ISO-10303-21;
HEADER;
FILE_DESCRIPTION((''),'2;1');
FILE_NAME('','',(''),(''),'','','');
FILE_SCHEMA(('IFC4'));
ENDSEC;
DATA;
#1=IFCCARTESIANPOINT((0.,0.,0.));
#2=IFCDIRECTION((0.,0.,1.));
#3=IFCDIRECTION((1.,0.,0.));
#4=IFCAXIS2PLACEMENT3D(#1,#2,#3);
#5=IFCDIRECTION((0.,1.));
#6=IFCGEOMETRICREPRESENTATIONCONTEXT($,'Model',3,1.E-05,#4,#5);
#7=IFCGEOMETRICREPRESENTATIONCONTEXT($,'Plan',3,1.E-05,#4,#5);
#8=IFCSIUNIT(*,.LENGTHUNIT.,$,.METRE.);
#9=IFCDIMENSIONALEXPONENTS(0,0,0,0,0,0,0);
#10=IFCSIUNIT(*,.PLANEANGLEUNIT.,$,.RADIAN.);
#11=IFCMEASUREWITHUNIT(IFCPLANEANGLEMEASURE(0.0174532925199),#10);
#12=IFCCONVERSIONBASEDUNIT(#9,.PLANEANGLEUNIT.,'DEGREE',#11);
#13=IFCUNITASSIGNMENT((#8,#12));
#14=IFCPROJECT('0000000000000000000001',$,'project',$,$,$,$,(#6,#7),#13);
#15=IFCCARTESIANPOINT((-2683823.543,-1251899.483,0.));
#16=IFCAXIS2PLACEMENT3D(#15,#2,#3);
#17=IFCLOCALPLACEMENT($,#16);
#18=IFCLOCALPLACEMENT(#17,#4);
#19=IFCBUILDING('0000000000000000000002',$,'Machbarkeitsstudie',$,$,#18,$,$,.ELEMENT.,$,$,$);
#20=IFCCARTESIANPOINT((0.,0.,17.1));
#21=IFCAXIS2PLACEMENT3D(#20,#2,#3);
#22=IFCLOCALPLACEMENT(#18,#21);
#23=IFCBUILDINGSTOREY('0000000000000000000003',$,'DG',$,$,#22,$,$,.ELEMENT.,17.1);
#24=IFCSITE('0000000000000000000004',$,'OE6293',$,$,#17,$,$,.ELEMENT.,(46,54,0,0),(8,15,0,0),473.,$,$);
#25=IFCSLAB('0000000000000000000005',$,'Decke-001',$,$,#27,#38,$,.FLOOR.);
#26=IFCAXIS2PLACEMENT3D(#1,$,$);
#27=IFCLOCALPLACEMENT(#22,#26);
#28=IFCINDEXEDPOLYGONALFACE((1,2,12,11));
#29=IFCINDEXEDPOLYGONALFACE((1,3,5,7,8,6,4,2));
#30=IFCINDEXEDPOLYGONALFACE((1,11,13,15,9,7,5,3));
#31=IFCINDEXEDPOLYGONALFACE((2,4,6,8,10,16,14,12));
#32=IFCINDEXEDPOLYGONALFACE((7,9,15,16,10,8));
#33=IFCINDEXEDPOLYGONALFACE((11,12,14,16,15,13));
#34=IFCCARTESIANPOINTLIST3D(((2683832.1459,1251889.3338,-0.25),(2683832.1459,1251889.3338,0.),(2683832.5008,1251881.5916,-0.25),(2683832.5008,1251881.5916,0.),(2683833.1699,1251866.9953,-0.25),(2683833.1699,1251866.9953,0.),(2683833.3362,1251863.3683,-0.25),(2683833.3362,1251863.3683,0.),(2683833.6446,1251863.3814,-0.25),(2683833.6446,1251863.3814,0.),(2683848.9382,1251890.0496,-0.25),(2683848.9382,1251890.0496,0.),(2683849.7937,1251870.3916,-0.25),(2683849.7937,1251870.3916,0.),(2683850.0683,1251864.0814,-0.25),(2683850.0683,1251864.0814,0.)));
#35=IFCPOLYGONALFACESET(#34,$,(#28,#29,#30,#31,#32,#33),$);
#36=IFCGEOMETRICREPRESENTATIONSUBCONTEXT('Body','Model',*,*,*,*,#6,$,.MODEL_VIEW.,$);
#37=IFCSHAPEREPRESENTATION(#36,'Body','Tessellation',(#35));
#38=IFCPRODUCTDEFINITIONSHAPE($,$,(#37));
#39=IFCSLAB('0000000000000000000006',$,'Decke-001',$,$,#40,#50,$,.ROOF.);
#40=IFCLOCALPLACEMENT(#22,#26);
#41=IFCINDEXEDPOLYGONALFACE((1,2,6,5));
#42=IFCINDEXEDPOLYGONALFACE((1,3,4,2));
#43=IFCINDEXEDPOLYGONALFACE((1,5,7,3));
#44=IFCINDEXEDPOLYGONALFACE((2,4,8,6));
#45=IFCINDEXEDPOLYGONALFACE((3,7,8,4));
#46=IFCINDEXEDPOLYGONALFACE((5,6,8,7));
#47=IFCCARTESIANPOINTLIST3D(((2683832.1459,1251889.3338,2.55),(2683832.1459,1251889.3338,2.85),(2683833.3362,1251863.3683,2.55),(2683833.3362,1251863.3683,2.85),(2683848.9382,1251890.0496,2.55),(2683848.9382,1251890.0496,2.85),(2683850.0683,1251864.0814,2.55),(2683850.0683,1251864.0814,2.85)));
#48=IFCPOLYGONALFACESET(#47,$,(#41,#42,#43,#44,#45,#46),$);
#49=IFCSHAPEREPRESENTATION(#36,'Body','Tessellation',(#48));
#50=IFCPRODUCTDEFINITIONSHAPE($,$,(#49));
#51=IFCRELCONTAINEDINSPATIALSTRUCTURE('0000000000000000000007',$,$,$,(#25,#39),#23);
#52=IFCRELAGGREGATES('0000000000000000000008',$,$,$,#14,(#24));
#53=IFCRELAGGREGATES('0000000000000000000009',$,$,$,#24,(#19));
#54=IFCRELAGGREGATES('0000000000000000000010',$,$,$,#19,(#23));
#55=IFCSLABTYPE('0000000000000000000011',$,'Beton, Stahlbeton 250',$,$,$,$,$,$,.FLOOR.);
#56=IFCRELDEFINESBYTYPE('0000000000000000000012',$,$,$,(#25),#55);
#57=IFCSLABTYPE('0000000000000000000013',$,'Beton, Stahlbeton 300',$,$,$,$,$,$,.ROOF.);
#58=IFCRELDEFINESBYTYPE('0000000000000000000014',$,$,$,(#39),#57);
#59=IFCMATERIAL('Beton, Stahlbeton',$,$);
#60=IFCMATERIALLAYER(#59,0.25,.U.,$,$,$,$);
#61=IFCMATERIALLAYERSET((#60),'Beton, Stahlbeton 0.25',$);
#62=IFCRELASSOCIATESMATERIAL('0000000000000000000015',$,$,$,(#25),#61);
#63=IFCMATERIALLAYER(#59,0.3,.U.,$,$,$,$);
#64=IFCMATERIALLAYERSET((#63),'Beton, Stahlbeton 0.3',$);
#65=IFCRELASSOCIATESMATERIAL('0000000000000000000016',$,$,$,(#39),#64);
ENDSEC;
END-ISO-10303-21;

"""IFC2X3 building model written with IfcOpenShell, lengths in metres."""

from ifc_helpers import new_model, entity, si_unit, converted_unit, direction, frame, origin_with_axes, place, context, subcontext, project, spatial, polyline, outline, extrude, material, layer, layer_set, layer_usage, type_object, element, save


model = new_model("IFC2X3")

# Units and contexts
model_context = context("Model", 3, precision=1e-05, world=origin_with_axes(), true_north=direction((0.0, 1.0)))
plan_context = context("Plan", 3, precision=1e-05, world=origin_with_axes(), true_north=direction((0.0, 1.0)))
body_context = subcontext(model_context, "Body", "Model", "MODEL_VIEW")
ifc_project = project(units=[si_unit("LENGTHUNIT", "METRE"), converted_unit("PLANEANGLEUNIT", "DEGREE", entity("IfcPlaneAngleMeasure", 0.0174532925199), si_unit("PLANEANGLEUNIT", "RADIAN"), dimensions=[0, 0, 0, 0, 0, 0, 0])], contexts=[model_context, plan_context])

# Site, building, storey
site_placement = place(None, frame((-2683823.543, -1251899.483, 0.0), z_axis=(0.0, 0.0, 1.0), x_axis=(1.0, 0.0, 0.0)))
site = spatial("IfcSite", under=ifc_project, at=site_placement, Name="OE6293", CompositionType="ELEMENT", RefLatitude=(46, 54, 0, 0), RefLongitude=(8, 15, 0, 0), RefElevation=473.0)
building_placement = place(site_placement, origin_with_axes())
building = spatial("IfcBuilding", under=site, at=building_placement, Name="Machbarkeitsstudie", CompositionType="ELEMENT")
storey_placement = place(building_placement, frame((0.0, 0.0, 17.1), z_axis=(0.0, 0.0, 1.0), x_axis=(1.0, 0.0, 0.0)))
storey = spatial("IfcBuildingStorey", under=building, at=storey_placement, Name="DG", CompositionType="ELEMENT", Elevation=17.1)

# Slabs
ifc_material = material(Name="Beton, Stahlbeton")
ifc_layer_1 = layer(ifc_material, 0.25, ventilated="UNKNOWN")
ifc_layer_set_1 = layer_set([ifc_layer_1], Name="Beton, Stahlbeton 0.25")
ifc_layer_usage_1 = layer_usage(ifc_layer_set_1, "AXIS3", "NEGATIVE", 0.25)
slab_type_1 = type_object("IfcSlabType", Name="Beton, Stahlbeton 250", PredefinedType="FLOOR")
slab_1_placement = place(storey_placement, frame((2683832.1459, 1251889.3338, 0.0), z_axis=(0.0, 0.0, 1.0), x_axis=(1.0, 0.0, 0.0)))
element("IfcSlab", 1, at=slab_1_placement, inside=storey, type_object=slab_type_1, material=ifc_layer_usage_1, Name="Decke-001", PredefinedType="FLOOR", context=body_context, shape_type="SweptSolid", body=[
    extrude(outline(polyline([(0.0, 0.0), (0.3549, -7.7422), (1.024, -22.3384), (1.1902, -25.9655), (1.4987, -25.9523), (17.9223, -25.2524), (17.6477, -18.9421), (16.7923, 0.7158), (0.0, 0.0)])), frame((0.0, 0.0, -0.25), z_axis=(0.0, 0.0, 1.0), x_axis=(1.0, 0.0, 0.0)), (0.0, 0.0, 1.0), 0.25),
])
ifc_layer_2 = layer(ifc_material, 0.3, ventilated="UNKNOWN")
ifc_layer_set_2 = layer_set([ifc_layer_2], Name="Beton, Stahlbeton 0.3")
ifc_layer_usage_2 = layer_usage(ifc_layer_set_2, "AXIS3", "NEGATIVE", 0.3)
slab_type_2 = type_object("IfcSlabType", Name="Beton, Stahlbeton 300", PredefinedType="ROOF")
slab_2_placement = place(storey_placement, frame((2683832.1459, 1251889.3338, 2.85), z_axis=(0.0, 0.0, 1.0), x_axis=(1.0, 0.0, 0.0)))
element("IfcSlab", 2, at=slab_2_placement, inside=storey, type_object=slab_type_2, material=ifc_layer_usage_2, Name="Decke-001", PredefinedType="ROOF", context=body_context, shape_type="SweptSolid", body=[
    extrude(outline(polyline([(0.0, 0.0), (1.1902, -25.9655), (17.9223, -25.2524), (16.7923, 0.7158), (0.0, 0.0)])), frame((0.0, 0.0, -0.3), z_axis=(0.0, 0.0, 1.0), x_axis=(1.0, 0.0, 0.0)), (0.0, 0.0, 1.0), 0.3),
])

save(model, "model.ifc")
